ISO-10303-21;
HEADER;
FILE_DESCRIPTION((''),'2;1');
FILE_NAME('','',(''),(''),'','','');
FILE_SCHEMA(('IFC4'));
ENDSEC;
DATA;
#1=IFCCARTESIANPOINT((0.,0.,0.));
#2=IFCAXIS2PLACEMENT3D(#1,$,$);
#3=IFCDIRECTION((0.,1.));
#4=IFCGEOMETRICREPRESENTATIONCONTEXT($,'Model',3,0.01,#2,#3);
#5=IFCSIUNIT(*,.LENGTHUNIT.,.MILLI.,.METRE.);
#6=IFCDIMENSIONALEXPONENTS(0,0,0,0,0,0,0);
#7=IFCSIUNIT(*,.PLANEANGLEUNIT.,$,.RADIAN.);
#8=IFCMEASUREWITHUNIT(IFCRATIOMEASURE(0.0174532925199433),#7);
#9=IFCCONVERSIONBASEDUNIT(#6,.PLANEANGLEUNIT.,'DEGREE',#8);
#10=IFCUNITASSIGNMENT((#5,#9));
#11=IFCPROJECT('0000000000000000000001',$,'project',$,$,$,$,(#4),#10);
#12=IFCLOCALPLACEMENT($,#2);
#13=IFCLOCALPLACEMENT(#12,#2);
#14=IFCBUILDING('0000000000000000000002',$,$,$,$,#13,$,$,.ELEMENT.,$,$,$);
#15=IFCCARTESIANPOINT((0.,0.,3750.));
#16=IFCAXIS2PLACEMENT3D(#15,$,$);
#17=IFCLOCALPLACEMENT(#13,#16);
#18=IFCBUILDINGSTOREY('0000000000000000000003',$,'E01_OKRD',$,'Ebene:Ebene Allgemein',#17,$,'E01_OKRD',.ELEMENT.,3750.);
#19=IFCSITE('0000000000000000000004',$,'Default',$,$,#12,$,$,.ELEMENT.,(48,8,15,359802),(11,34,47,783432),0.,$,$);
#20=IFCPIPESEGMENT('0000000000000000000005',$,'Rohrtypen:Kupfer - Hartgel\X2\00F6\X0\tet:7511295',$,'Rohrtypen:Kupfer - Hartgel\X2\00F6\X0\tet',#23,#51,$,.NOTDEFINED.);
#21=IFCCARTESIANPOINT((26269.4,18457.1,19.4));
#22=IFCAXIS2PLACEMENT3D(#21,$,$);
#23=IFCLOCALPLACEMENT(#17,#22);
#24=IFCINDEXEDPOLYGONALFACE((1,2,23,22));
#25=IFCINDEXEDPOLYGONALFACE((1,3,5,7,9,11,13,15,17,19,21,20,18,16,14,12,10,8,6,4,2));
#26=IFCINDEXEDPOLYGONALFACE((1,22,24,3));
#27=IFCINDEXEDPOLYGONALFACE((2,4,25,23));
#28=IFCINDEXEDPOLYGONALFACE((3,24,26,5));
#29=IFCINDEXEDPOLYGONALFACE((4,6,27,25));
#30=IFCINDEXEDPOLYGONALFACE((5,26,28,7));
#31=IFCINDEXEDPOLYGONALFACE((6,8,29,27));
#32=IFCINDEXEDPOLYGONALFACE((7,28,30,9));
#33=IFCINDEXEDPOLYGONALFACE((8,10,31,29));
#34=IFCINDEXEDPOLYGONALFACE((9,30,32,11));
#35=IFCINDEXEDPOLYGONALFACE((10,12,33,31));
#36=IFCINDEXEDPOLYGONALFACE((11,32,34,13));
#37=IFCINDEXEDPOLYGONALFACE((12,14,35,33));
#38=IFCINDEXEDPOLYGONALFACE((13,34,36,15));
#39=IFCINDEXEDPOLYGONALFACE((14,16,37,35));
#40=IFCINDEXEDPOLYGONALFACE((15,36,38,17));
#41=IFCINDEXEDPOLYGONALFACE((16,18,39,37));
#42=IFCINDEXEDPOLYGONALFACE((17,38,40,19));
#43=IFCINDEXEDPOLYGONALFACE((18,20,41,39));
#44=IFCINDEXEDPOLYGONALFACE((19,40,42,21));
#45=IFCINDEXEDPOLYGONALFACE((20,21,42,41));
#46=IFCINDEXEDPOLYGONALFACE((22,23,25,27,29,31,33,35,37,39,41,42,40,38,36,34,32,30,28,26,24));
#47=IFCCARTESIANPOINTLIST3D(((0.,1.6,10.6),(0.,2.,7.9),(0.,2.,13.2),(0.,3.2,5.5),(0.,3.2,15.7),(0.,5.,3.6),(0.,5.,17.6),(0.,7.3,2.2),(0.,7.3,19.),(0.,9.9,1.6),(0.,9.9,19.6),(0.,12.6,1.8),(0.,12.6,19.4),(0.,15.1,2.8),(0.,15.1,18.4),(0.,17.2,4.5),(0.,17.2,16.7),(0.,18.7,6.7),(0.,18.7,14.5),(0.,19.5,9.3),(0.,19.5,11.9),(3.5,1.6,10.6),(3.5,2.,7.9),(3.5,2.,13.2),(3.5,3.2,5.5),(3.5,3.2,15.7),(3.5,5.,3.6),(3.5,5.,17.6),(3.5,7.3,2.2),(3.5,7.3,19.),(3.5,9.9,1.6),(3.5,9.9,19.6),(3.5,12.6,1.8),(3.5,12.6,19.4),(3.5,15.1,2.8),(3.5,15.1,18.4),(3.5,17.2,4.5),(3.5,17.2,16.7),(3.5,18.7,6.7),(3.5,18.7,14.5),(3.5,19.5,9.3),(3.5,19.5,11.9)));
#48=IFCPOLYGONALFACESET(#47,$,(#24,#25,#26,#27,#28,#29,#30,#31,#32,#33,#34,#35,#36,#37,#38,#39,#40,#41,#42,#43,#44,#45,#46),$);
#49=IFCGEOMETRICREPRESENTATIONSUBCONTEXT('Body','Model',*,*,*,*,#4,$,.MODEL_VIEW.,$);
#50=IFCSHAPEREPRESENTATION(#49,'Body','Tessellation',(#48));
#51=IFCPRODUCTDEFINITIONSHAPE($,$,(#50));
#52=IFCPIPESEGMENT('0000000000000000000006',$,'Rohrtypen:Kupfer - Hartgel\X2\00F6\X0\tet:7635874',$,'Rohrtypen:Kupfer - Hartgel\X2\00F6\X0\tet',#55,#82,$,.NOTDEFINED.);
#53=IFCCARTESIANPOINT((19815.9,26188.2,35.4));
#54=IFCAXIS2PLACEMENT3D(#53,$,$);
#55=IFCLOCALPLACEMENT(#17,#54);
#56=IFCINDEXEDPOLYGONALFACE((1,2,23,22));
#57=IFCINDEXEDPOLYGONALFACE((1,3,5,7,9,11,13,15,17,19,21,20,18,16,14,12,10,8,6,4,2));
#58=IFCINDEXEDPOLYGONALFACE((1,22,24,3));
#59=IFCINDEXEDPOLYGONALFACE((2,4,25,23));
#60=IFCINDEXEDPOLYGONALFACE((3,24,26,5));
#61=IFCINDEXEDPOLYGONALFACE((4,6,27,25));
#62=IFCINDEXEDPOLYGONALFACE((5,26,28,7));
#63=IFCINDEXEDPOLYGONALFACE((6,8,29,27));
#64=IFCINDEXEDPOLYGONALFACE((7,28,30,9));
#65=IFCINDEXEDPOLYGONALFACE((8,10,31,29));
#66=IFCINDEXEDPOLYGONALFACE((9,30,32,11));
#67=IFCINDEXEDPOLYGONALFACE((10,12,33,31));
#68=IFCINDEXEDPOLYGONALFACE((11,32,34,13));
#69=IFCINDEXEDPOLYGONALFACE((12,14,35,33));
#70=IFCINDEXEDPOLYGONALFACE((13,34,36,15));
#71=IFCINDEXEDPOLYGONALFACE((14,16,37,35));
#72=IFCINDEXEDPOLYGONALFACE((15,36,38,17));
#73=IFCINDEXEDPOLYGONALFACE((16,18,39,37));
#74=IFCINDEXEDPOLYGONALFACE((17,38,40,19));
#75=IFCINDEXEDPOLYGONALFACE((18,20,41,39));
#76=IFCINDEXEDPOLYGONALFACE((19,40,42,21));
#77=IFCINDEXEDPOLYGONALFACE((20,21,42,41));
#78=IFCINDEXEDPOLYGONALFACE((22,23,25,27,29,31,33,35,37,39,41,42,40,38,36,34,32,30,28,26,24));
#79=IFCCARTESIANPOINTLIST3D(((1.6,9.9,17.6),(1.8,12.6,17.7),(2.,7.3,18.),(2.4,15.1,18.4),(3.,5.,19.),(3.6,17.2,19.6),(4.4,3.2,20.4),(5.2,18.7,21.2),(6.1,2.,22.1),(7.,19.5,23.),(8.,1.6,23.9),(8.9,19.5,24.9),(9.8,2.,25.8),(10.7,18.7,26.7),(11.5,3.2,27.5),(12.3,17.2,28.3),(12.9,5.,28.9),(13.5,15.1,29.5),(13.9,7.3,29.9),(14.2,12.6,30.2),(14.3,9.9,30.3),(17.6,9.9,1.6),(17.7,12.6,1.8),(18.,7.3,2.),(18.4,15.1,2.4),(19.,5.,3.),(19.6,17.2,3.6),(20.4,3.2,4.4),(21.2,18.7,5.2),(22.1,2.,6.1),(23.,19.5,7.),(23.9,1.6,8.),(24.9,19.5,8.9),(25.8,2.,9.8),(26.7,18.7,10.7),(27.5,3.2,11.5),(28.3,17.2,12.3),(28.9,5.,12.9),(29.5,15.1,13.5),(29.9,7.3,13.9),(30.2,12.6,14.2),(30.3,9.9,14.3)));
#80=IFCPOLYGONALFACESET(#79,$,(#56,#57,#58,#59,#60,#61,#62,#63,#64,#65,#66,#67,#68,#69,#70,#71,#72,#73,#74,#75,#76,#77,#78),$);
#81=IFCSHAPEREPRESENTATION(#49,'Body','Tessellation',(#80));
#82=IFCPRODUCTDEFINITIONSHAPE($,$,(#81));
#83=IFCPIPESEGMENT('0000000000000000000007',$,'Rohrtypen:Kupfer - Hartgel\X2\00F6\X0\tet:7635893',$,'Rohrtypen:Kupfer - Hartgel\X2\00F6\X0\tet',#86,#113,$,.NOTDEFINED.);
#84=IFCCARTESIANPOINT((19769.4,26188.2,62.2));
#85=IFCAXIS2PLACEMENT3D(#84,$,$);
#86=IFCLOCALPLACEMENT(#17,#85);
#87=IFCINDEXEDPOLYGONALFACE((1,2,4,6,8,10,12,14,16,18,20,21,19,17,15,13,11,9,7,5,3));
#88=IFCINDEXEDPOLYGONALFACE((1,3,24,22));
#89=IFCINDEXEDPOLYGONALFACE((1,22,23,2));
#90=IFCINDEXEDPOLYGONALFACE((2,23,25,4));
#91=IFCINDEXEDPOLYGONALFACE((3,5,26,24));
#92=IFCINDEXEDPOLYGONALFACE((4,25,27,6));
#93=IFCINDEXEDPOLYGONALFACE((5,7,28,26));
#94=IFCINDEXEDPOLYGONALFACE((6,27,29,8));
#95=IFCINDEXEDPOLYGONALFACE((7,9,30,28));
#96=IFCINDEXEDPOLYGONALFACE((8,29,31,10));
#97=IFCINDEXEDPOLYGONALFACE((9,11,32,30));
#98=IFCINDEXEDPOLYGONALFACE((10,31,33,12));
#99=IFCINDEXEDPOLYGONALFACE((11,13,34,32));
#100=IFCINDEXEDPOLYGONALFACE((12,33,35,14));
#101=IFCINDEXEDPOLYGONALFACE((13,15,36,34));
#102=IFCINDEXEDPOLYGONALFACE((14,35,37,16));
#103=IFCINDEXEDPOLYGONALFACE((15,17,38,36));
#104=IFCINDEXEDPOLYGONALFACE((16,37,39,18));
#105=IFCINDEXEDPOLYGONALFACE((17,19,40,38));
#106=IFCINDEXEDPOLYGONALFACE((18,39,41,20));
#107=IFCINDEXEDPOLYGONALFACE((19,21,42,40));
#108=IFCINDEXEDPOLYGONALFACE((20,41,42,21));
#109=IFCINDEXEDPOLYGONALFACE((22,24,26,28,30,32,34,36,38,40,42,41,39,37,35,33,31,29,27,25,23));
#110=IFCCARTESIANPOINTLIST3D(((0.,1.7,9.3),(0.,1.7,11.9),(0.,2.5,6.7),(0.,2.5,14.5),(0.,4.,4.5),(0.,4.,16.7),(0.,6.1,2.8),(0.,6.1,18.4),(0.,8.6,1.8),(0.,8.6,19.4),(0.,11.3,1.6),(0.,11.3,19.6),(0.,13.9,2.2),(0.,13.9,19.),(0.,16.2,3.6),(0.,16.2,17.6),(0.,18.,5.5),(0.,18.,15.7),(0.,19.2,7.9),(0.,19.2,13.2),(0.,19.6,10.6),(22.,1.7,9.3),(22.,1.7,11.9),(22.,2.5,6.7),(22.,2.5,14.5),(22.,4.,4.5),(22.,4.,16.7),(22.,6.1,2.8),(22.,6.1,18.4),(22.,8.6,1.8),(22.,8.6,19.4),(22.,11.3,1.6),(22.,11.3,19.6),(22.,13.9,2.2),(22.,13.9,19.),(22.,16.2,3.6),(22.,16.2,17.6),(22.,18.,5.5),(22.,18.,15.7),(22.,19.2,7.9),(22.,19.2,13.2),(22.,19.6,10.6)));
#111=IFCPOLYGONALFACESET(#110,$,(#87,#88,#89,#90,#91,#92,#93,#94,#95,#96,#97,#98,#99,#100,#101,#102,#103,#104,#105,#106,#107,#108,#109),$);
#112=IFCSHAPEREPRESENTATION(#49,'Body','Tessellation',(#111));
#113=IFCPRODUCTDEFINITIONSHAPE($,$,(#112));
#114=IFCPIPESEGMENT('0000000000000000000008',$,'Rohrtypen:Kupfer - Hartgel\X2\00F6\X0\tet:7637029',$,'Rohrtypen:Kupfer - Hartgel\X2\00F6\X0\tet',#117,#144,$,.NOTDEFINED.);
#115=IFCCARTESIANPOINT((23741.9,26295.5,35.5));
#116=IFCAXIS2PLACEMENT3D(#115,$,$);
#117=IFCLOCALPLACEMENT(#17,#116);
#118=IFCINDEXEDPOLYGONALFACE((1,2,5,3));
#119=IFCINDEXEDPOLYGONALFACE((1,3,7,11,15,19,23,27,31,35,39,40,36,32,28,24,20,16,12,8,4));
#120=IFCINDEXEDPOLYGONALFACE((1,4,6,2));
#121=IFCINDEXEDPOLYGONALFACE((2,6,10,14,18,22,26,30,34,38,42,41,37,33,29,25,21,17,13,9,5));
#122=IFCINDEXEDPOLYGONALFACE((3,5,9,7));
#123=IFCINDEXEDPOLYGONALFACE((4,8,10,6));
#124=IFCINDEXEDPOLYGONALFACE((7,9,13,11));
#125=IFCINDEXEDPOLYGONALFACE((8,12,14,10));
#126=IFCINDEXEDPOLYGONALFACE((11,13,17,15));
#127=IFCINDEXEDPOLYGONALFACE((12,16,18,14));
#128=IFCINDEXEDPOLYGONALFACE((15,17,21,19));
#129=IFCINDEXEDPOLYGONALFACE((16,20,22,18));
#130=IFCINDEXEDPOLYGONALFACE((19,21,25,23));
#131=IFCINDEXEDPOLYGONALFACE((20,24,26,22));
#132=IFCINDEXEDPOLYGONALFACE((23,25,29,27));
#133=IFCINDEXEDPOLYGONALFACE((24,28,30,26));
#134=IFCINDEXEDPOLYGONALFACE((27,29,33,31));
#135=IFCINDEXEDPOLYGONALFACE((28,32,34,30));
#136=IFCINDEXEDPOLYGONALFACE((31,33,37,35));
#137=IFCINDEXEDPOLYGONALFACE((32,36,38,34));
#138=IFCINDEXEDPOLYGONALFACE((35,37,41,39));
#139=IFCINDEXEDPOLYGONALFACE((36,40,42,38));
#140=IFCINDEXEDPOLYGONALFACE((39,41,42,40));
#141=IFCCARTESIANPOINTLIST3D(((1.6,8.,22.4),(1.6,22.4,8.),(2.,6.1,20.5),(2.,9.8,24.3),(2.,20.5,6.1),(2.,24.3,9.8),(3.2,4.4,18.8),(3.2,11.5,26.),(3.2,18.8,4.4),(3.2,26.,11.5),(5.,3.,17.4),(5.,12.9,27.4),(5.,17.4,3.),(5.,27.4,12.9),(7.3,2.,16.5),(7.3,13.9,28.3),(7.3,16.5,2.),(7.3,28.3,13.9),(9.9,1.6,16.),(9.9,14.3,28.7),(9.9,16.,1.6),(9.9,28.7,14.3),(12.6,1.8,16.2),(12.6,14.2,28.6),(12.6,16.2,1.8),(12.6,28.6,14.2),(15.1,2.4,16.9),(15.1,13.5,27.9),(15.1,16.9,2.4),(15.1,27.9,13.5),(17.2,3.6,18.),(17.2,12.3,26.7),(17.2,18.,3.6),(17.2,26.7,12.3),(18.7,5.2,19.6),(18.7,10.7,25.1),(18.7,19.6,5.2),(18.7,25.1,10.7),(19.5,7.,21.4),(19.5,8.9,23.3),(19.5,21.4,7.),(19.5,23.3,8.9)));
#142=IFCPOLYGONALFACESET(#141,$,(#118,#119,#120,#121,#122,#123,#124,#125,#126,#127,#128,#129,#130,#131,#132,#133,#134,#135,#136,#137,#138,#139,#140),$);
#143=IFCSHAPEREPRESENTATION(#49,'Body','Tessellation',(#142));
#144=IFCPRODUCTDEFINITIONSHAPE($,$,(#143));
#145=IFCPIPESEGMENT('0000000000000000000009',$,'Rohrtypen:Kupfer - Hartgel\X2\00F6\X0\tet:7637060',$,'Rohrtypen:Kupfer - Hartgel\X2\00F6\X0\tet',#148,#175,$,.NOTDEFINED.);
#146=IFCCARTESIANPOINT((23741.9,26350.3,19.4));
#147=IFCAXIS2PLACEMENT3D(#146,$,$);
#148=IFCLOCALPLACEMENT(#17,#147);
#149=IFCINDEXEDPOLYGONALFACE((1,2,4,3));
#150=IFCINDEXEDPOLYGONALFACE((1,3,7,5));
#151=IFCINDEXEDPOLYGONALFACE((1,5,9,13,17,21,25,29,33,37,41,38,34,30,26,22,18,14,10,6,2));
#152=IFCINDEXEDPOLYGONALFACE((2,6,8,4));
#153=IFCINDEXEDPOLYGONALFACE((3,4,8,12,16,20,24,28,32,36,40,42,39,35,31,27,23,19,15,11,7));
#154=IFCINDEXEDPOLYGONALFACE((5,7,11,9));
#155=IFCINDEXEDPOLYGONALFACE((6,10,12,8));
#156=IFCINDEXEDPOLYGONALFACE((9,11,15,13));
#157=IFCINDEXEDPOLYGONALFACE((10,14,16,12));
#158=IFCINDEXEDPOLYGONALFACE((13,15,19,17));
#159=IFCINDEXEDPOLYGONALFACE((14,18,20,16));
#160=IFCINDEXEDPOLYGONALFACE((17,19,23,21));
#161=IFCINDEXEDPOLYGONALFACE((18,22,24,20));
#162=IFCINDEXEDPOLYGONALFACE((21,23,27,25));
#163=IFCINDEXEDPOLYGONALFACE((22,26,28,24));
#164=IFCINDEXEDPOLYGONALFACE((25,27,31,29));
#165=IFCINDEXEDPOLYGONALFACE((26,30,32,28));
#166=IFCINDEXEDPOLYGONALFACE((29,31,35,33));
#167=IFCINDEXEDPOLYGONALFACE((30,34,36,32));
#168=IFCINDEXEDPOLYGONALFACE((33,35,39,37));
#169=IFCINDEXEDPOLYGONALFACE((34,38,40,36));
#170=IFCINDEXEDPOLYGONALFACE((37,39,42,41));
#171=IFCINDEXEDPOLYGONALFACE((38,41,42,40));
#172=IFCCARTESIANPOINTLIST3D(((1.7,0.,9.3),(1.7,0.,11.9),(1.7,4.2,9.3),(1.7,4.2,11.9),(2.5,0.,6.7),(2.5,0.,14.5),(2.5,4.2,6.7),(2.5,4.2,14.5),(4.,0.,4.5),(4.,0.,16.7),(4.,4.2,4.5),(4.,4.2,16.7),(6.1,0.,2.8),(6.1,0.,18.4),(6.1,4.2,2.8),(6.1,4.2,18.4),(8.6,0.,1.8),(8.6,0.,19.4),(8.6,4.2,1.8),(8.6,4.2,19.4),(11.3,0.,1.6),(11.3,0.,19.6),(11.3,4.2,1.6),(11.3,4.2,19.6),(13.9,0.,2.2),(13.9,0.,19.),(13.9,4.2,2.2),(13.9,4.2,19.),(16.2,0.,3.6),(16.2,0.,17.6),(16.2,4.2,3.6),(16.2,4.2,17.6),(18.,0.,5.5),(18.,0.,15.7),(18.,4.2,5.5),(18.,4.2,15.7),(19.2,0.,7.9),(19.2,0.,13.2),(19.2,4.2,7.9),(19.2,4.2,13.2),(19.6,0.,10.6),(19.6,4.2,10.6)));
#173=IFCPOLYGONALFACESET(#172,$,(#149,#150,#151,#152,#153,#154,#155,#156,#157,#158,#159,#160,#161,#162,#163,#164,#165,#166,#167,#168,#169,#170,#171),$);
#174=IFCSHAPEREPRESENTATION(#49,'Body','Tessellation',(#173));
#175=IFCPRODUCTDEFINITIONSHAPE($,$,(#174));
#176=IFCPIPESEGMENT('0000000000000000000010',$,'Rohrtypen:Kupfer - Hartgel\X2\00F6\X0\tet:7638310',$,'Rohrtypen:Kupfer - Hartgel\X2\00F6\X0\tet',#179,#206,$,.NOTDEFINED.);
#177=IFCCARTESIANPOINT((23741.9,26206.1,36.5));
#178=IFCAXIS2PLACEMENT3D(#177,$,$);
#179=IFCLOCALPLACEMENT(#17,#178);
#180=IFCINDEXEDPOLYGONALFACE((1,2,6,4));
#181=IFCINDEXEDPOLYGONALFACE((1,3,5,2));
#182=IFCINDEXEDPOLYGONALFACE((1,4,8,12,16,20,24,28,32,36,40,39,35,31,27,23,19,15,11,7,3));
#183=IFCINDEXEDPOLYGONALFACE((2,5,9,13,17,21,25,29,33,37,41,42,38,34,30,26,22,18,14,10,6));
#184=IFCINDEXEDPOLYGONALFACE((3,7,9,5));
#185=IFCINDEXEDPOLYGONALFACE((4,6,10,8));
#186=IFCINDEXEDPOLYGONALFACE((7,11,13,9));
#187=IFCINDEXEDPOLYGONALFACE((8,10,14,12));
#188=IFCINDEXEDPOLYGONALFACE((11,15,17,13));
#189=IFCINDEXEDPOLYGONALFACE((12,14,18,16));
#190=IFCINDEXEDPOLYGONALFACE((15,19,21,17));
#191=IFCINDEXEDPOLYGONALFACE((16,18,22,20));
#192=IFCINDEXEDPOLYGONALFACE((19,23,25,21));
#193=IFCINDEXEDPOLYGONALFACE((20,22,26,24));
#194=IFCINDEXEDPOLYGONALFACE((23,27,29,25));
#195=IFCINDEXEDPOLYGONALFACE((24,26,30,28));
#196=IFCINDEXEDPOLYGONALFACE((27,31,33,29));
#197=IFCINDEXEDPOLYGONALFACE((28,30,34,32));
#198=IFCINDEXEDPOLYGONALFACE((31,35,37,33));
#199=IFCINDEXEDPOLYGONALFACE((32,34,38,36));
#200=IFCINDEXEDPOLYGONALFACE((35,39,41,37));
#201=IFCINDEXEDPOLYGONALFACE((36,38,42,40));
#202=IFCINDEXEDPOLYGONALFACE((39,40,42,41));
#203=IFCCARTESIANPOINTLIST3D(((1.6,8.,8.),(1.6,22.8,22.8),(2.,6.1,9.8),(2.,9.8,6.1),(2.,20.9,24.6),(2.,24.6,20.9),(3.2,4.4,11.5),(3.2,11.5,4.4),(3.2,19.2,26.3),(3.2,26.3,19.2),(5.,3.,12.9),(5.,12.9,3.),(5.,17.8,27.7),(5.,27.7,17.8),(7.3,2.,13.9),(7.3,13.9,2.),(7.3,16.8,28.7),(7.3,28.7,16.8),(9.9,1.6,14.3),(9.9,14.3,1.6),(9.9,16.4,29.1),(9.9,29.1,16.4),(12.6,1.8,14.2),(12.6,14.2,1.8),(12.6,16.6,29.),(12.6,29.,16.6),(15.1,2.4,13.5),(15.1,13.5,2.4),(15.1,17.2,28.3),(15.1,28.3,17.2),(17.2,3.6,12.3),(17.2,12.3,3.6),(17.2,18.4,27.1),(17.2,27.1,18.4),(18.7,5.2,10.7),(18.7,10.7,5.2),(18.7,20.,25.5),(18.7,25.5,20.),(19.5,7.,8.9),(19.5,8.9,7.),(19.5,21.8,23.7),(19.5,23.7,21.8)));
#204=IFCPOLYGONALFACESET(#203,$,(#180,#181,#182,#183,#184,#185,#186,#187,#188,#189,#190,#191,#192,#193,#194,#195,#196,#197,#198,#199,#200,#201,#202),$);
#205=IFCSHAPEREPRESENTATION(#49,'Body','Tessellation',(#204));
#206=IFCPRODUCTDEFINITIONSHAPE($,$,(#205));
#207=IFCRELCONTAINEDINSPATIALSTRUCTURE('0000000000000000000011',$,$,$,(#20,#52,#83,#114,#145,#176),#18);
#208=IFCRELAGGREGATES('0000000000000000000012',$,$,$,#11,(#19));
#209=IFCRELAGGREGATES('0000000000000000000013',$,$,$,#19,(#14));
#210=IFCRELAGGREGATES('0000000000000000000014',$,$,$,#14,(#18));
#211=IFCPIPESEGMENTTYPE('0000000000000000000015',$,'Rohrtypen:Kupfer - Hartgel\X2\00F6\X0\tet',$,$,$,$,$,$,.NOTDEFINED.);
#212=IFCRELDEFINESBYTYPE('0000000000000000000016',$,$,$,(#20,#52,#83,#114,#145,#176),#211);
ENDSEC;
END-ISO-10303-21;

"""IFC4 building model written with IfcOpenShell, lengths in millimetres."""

from ifc_helpers import new_model, entity, si_unit, converted_unit, direction, frame, frame_2d, origin, origin_2d_with_axis, place, context, subcontext, project, spatial, circle, extrude, type_object, element, save


model = new_model("IFC4")

# Units and contexts
model_context = context("Model", 3, precision=0.01, world=origin(), true_north=direction((0.0, 1.0)))
body_context = subcontext(model_context, "Body", "Model", "MODEL_VIEW")
ifc_project = project(units=[si_unit("LENGTHUNIT", "METRE", prefix="MILLI"), converted_unit("PLANEANGLEUNIT", "DEGREE", entity("IfcRatioMeasure", 0.0174532925199433), si_unit("PLANEANGLEUNIT", "RADIAN"), dimensions=[0, 0, 0, 0, 0, 0, 0])], contexts=[model_context])

# Site, building, storey
site_placement = place(None, origin())
site = spatial("IfcSite", under=ifc_project, at=site_placement, Name="Default", CompositionType="ELEMENT", RefLatitude=(48, 8, 15, 359802), RefLongitude=(11, 34, 47, 783432), RefElevation=0.0)
building_placement = place(site_placement, origin())
building = spatial("IfcBuilding", under=site, at=building_placement, CompositionType="ELEMENT")
storey_placement = place(building_placement, frame((0.0, 0.0, 3750.0)))
storey = spatial("IfcBuildingStorey", under=building, at=storey_placement, Name="E01_OKRD", ObjectType="Ebene:Ebene Allgemein", LongName="E01_OKRD", CompositionType="ELEMENT", Elevation=3750.0)

# Pipe segments
pipe_segment_type = type_object("IfcPipeSegmentType", Name="Rohrtypen:Kupfer - Hartgelötet", PredefinedType="NOTDEFINED")
pipe_segment_1_placement = place(storey_placement, frame((26269.4, 18457.1, 19.4)))
element("IfcPipeSegment", 1, at=pipe_segment_1_placement, inside=storey, type_object=pipe_segment_type, Name="Rohrtypen:Kupfer - Hartgelötet:7511295", ObjectType="Rohrtypen:Kupfer - Hartgelötet", PredefinedType="NOTDEFINED", context=body_context, shape_type="SweptSolid", body=[
    extrude(circle(Radius=9.0, at=origin_2d_with_axis()), frame((0.0, 10.6, 10.6), z_axis=(1.0, 0.0, 0.0), x_axis=(0.0, -1.0, 0.0)), (0.0, 0.0, 1.0), 3.5),
])
pipe_segment_2_placement = place(storey_placement, frame((19815.9, 26188.2, 35.4)))
element("IfcPipeSegment", 2, at=pipe_segment_2_placement, inside=storey, type_object=pipe_segment_type, Name="Rohrtypen:Kupfer - Hartgelötet:7635874", ObjectType="Rohrtypen:Kupfer - Hartgelötet", PredefinedType="NOTDEFINED", context=body_context, shape_type="SweptSolid", body=[
    extrude(circle(Radius=9.0, at=frame_2d((0.0, 0.0), x_axis=(1.0, 0.0))), frame((23.9, 10.6, 8.0), z_axis=(-0.707107, 0.0, 0.707107), x_axis=(0.0, -1.0, 0.0)), (0.0, 0.0, 1.0), 22.6),
])
pipe_segment_3_placement = place(storey_placement, frame((19769.4, 26188.2, 62.2)))
element("IfcPipeSegment", 3, at=pipe_segment_3_placement, inside=storey, type_object=pipe_segment_type, Name="Rohrtypen:Kupfer - Hartgelötet:7635893", ObjectType="Rohrtypen:Kupfer - Hartgelötet", PredefinedType="NOTDEFINED", context=body_context, shape_type="SweptSolid", body=[
    extrude(circle(Radius=9.0, at=origin_2d_with_axis()), frame((0.0, 10.6, 10.6), z_axis=(1.0, 0.0, 0.0), x_axis=(0.0, 1.0, 0.0)), (0.0, 0.0, 1.0), 22.0),
])
pipe_segment_4_placement = place(storey_placement, frame((23741.9, 26295.5, 35.5)))
element("IfcPipeSegment", 4, at=pipe_segment_4_placement, inside=storey, type_object=pipe_segment_type, Name="Rohrtypen:Kupfer - Hartgelötet:7637029", ObjectType="Rohrtypen:Kupfer - Hartgelötet", PredefinedType="NOTDEFINED", context=body_context, shape_type="SweptSolid", body=[
    extrude(circle(Radius=9.0, at=origin_2d_with_axis()), frame((10.6, 22.4, 8.0), z_axis=(0.0, -0.707107, 0.707107), x_axis=(-1.0, 0.0, 0.0)), (0.0, 0.0, 1.0), 20.4),
])
pipe_segment_5_placement = place(storey_placement, frame((23741.9, 26350.3, 19.4)))
element("IfcPipeSegment", 5, at=pipe_segment_5_placement, inside=storey, type_object=pipe_segment_type, Name="Rohrtypen:Kupfer - Hartgelötet:7637060", ObjectType="Rohrtypen:Kupfer - Hartgelötet", PredefinedType="NOTDEFINED", context=body_context, shape_type="SweptSolid", body=[
    extrude(circle(Radius=9.0, at=origin_2d_with_axis()), frame((10.6, 0.0, 10.6), z_axis=(0.0, 1.0, 0.0), x_axis=(1.0, 0.0, 0.0)), (0.0, 0.0, 1.0), 4.2),
])
pipe_segment_6_placement = place(storey_placement, frame((23741.9, 26206.1, 36.5)))
element("IfcPipeSegment", 6, at=pipe_segment_6_placement, inside=storey, type_object=pipe_segment_type, Name="Rohrtypen:Kupfer - Hartgelötet:7638310", ObjectType="Rohrtypen:Kupfer - Hartgelötet", PredefinedType="NOTDEFINED", context=body_context, shape_type="SweptSolid", body=[
    extrude(circle(Radius=9.0, at=frame_2d((0.0, 0.0), x_axis=(1.0, 0.0))), frame((10.6, 8.0, 8.0), z_axis=(0.0, 0.707107, 0.707107), x_axis=(-1.0, 0.0, 0.0)), (0.0, 0.0, 1.0), 20.9),
])

save(model, "model.ifc")
